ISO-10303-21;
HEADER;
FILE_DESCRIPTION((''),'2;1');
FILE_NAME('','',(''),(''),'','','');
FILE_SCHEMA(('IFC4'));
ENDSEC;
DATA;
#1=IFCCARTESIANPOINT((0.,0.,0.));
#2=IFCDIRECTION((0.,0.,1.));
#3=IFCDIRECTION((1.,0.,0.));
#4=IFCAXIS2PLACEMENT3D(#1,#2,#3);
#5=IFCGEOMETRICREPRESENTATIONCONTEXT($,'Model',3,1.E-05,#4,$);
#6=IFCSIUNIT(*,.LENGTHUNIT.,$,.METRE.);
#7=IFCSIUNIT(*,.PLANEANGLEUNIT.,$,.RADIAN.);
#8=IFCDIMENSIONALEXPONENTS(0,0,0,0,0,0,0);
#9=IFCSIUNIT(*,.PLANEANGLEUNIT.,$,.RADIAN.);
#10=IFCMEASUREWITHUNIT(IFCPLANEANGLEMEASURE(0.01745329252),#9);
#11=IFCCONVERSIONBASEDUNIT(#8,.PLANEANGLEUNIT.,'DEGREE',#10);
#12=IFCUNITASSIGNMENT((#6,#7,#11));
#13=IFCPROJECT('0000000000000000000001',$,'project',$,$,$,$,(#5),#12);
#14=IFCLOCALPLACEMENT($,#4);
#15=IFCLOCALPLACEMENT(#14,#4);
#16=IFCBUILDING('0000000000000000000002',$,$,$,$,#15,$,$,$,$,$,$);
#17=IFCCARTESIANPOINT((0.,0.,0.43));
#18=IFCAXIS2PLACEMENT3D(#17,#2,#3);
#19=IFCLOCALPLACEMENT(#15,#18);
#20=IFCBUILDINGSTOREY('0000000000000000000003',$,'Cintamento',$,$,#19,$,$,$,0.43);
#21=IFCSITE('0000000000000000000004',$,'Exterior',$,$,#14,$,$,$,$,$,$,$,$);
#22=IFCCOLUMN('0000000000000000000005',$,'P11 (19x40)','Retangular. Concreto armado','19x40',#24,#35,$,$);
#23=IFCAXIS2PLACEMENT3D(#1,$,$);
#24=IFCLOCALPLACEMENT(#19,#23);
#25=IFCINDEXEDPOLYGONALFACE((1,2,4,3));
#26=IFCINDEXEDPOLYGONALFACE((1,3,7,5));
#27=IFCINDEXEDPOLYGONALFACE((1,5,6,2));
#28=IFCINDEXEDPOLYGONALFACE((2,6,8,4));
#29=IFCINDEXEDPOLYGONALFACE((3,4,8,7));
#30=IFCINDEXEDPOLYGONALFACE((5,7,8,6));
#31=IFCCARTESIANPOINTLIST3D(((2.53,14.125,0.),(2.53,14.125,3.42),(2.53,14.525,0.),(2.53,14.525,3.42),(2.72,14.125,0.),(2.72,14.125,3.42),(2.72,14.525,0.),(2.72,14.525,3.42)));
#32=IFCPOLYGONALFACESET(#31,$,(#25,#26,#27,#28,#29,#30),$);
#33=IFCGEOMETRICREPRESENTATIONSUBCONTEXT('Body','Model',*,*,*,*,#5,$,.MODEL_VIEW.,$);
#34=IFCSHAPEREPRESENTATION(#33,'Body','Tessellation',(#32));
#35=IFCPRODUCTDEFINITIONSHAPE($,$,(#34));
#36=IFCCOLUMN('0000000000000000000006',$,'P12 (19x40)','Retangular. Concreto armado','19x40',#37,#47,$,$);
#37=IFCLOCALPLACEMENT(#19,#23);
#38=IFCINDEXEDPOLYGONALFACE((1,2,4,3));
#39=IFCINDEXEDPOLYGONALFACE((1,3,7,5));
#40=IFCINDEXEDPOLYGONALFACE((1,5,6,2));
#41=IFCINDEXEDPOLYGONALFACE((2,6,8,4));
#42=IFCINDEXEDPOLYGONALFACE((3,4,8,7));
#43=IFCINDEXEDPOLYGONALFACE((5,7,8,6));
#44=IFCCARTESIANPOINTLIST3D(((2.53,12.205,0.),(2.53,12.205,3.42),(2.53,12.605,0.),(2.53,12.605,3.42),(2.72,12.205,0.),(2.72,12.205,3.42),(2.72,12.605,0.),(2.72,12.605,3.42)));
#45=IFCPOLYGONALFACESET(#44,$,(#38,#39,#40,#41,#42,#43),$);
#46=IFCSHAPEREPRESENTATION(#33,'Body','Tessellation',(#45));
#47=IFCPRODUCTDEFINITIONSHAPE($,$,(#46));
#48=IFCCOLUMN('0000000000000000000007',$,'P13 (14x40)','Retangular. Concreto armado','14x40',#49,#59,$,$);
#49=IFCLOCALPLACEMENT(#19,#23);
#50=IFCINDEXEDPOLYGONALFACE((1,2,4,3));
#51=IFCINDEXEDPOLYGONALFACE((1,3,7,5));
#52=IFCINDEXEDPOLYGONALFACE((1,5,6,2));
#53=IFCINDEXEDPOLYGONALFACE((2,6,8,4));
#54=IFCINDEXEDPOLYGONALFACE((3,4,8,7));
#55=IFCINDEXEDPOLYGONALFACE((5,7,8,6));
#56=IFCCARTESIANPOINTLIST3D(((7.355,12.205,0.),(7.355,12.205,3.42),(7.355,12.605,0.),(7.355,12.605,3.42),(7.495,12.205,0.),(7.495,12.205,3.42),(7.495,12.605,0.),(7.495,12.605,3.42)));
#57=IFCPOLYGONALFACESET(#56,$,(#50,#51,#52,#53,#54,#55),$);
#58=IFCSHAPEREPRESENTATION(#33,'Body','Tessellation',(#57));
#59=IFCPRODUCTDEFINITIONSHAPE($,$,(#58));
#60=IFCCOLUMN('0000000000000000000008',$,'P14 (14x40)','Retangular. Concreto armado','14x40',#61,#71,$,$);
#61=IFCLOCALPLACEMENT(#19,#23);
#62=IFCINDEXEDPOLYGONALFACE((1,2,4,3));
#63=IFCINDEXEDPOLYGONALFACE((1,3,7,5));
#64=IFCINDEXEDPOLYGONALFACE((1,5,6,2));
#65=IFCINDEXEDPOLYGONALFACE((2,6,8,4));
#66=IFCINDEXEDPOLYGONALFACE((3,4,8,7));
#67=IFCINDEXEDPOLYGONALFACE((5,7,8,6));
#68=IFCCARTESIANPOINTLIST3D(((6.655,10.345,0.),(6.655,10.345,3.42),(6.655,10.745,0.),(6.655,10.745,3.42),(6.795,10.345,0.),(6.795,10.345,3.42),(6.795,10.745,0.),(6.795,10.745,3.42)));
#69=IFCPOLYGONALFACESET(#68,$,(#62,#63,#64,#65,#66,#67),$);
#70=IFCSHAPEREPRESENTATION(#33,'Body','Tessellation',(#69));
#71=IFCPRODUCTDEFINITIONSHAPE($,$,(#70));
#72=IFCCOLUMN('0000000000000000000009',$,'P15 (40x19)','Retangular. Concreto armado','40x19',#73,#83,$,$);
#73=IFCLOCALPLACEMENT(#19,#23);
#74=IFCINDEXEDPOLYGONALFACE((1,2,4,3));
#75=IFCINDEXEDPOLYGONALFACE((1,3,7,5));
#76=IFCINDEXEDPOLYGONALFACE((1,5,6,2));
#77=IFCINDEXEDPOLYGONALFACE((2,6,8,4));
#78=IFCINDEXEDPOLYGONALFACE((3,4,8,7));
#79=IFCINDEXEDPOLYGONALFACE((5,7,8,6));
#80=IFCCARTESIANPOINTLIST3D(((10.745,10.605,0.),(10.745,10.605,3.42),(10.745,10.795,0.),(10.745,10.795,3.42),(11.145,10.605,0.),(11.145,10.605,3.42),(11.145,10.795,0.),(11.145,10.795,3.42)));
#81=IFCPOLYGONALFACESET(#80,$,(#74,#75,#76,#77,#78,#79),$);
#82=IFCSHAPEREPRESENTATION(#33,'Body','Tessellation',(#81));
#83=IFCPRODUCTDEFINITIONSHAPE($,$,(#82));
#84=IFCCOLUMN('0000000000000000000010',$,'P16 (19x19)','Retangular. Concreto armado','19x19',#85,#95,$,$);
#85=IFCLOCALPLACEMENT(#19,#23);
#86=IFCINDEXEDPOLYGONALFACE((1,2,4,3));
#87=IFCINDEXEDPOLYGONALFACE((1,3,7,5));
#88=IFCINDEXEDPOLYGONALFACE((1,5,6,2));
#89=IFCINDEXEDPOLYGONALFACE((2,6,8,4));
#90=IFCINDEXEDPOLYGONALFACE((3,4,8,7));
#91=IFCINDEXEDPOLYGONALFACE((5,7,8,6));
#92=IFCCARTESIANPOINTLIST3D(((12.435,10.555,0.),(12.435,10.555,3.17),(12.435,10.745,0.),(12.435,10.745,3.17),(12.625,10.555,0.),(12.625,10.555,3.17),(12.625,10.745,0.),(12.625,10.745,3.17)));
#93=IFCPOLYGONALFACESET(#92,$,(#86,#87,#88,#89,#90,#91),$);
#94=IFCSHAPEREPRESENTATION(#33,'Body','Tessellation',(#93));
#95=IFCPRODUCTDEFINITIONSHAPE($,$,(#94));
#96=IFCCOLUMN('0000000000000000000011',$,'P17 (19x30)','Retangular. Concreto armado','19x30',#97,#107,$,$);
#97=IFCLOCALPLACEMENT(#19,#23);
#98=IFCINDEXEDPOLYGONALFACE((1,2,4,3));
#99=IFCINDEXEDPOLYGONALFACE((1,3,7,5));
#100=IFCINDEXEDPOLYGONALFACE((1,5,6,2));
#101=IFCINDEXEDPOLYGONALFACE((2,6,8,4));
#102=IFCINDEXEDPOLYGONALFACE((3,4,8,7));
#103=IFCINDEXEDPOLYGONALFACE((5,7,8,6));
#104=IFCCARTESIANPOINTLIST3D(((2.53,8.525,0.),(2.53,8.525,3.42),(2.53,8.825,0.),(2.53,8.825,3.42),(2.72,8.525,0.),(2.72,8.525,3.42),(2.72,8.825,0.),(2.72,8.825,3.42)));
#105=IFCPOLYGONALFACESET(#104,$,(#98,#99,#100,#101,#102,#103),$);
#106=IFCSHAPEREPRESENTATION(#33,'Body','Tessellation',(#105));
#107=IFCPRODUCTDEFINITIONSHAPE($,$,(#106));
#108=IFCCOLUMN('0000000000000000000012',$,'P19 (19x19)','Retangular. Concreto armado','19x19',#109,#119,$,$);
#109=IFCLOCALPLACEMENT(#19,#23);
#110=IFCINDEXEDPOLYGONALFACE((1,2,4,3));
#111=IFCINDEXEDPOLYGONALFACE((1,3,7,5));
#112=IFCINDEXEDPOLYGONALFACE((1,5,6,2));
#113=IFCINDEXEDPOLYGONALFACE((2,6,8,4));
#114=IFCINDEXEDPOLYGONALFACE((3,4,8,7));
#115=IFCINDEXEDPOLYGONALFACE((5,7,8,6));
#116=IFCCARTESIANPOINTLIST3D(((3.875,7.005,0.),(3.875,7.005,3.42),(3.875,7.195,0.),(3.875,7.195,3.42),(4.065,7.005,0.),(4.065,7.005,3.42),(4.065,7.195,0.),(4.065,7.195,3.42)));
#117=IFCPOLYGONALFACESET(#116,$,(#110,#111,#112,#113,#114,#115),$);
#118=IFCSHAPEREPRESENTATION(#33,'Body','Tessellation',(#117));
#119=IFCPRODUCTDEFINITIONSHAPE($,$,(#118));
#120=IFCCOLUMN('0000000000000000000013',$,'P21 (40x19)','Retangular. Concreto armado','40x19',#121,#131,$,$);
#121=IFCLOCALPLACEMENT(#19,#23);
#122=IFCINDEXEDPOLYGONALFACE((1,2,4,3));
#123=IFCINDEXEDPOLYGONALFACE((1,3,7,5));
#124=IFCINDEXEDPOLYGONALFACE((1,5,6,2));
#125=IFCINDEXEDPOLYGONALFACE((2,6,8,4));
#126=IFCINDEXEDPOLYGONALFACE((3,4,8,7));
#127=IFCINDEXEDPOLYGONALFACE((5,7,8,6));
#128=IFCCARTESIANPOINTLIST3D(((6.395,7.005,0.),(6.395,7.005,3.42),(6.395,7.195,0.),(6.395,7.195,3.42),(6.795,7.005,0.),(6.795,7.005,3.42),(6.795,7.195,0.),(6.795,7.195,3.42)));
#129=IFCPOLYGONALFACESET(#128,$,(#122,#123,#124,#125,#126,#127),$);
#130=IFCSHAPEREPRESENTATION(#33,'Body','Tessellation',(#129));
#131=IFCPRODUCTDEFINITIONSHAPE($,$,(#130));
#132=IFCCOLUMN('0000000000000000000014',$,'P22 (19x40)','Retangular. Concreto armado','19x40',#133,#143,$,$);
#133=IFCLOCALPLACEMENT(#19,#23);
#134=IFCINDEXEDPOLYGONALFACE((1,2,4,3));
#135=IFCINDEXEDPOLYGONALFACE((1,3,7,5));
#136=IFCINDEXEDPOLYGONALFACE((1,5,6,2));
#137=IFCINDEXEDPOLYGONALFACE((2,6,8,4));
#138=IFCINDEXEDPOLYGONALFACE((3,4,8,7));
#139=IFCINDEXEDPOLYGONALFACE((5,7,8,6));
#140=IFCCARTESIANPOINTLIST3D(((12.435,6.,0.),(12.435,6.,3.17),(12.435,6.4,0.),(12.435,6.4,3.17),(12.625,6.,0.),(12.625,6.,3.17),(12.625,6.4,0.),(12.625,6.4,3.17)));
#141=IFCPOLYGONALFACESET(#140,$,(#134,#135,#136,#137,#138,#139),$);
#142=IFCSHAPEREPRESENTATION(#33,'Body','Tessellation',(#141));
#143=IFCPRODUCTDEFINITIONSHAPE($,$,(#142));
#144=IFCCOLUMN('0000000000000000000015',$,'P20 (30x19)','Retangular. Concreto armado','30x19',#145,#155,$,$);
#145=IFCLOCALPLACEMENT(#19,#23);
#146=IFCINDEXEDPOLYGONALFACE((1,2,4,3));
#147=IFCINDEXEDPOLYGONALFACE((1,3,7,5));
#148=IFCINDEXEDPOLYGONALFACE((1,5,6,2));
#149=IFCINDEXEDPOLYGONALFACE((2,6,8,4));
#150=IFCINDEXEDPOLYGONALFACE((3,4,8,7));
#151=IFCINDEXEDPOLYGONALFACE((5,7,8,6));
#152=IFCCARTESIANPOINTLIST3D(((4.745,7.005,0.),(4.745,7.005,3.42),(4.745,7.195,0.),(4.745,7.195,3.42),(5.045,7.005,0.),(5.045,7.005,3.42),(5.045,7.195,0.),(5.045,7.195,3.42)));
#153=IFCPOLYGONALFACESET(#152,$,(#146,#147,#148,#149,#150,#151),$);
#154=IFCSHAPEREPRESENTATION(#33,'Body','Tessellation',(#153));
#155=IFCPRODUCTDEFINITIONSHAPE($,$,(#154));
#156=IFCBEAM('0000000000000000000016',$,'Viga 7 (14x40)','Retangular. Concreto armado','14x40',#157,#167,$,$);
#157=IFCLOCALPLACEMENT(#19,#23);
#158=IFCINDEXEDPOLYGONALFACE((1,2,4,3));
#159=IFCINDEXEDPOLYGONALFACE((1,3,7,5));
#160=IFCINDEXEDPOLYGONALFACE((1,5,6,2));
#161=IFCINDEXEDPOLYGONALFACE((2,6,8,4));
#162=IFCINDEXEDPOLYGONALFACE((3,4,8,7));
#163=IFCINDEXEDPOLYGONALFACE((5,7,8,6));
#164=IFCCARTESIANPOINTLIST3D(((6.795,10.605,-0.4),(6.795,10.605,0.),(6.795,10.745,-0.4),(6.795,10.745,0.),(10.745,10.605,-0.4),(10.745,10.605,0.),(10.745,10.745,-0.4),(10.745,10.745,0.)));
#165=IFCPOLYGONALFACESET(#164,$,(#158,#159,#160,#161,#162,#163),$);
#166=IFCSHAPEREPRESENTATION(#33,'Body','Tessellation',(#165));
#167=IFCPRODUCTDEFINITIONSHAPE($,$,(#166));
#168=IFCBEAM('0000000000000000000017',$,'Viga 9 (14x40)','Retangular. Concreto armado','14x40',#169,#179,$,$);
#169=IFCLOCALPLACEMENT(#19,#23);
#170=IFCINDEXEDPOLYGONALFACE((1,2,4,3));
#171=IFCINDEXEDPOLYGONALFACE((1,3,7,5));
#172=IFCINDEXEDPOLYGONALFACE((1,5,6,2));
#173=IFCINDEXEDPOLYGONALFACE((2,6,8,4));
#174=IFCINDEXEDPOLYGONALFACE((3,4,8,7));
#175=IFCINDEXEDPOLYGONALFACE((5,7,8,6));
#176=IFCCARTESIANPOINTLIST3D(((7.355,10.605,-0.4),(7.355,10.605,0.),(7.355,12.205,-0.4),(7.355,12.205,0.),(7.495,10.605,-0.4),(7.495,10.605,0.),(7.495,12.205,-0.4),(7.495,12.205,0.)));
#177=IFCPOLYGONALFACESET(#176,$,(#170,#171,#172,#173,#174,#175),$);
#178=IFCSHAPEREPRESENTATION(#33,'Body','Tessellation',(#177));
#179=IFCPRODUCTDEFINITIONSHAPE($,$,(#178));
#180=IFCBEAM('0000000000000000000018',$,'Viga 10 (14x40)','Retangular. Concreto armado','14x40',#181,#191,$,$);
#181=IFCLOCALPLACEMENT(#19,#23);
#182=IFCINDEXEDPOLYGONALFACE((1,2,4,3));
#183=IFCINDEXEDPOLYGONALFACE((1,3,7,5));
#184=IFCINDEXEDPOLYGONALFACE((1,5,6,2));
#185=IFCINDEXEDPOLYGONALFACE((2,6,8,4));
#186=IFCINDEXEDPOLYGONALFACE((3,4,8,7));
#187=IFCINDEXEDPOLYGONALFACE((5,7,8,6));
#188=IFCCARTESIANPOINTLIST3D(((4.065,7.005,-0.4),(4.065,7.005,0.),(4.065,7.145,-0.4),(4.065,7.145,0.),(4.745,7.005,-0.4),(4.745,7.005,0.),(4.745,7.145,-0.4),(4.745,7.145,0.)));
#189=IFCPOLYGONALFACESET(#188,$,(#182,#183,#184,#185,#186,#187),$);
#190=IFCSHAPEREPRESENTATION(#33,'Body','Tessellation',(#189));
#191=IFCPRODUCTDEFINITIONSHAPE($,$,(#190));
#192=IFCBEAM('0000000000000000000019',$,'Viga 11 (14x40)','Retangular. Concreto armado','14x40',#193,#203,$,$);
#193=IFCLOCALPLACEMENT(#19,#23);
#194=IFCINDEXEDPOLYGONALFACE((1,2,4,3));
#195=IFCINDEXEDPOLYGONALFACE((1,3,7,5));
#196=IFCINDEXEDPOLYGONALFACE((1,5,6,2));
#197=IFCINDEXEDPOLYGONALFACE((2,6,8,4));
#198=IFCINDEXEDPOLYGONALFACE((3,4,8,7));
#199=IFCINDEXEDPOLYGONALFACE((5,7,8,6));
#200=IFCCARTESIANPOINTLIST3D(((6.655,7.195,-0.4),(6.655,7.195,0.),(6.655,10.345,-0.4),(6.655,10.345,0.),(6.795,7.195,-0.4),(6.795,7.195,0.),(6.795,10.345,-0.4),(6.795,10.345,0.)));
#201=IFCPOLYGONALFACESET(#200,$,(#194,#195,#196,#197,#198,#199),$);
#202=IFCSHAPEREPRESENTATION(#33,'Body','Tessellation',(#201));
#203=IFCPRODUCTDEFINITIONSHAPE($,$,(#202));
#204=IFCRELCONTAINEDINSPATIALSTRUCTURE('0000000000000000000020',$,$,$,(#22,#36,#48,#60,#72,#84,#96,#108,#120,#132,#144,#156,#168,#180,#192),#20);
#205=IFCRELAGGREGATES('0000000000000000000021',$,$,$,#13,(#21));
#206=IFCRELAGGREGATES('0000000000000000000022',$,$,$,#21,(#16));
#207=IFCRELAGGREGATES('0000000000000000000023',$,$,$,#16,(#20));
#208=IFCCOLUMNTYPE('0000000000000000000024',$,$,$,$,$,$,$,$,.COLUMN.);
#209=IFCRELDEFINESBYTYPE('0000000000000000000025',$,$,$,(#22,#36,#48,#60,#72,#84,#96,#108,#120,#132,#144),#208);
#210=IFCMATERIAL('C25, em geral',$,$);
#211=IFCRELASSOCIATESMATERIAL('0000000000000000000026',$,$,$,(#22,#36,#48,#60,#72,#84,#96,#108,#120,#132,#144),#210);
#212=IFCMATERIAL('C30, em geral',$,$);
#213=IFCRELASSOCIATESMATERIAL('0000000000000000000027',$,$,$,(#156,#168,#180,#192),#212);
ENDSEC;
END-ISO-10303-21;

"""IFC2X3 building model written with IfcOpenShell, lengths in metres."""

from ifc_helpers import new_model, entity, si_unit, converted_unit, frame, frame_2d, origin_with_axes, place, context, subcontext, project, spatial, rectangle, extrude, material, type_object, element, save


model = new_model("IFC2X3")

# Units and contexts
model_context = context("Model", 3, precision=1e-05, world=origin_with_axes())
body_context = subcontext(model_context, "Body", "Model", "MODEL_VIEW")
ifc_project = project(units=[si_unit("LENGTHUNIT", "METRE"), si_unit("PLANEANGLEUNIT", "RADIAN"), converted_unit("PLANEANGLEUNIT", "DEGREE", entity("IfcPlaneAngleMeasure", 0.01745329252), si_unit("PLANEANGLEUNIT", "RADIAN"), dimensions=[0, 0, 0, 0, 0, 0, 0])], contexts=[model_context])

# Site, building, storey
site_placement = place(None, origin_with_axes())
site = spatial("IfcSite", under=ifc_project, at=site_placement, Name="Exterior")
building_placement = place(site_placement, origin_with_axes())
building = spatial("IfcBuilding", under=site, at=building_placement)
storey_placement = place(building_placement, frame((0.0, 0.0, 0.43), z_axis=(0.0, 0.0, 1.0), x_axis=(1.0, 0.0, 0.0)))
storey = spatial("IfcBuildingStorey", under=building, at=storey_placement, Name="Cintamento", Elevation=0.43)

# Columns
ifc_material_1 = material(Name="C25, em geral")
column_type = type_object("IfcColumnType", PredefinedType="COLUMN")
column_1_placement = place(storey_placement, frame((2.53, 14.525, 0.0), z_axis=(0.0, 0.0, 1.0), x_axis=(1.0, 0.0, 0.0)))
element("IfcColumn", 1, at=column_1_placement, inside=storey, type_object=column_type, material=ifc_material_1, Name="P11 (19x40)", Description="Retangular. Concreto armado", ObjectType="19x40", context=body_context, shape_type="SweptSolid", body=[
    extrude(rectangle(XDim=0.19, YDim=0.4, at=frame_2d((0.095, -0.2), x_axis=(1.0, 0.0))), origin_with_axes(), (0.0, 0.0, 1.0), 3.42),
])
column_2_placement = place(storey_placement, frame((2.53, 12.205, 0.0), z_axis=(0.0, 0.0, 1.0), x_axis=(1.0, 0.0, 0.0)))
element("IfcColumn", 2, at=column_2_placement, inside=storey, type_object=column_type, material=ifc_material_1, Name="P12 (19x40)", Description="Retangular. Concreto armado", ObjectType="19x40", context=body_context, shape_type="SweptSolid", body=[
    extrude(rectangle(XDim=0.19, YDim=0.4, at=frame_2d((0.095, 0.2), x_axis=(1.0, 0.0))), origin_with_axes(), (0.0, 0.0, 1.0), 3.42),
])
column_3_placement = place(storey_placement, frame((7.495, 12.205, 0.0), z_axis=(0.0, 0.0, 1.0), x_axis=(1.0, 0.0, 0.0)))
element("IfcColumn", 3, at=column_3_placement, inside=storey, type_object=column_type, material=ifc_material_1, Name="P13 (14x40)", Description="Retangular. Concreto armado", ObjectType="14x40", context=body_context, shape_type="SweptSolid", body=[
    extrude(rectangle(XDim=0.14, YDim=0.4, at=frame_2d((-0.07, 0.2), x_axis=(1.0, 0.0))), origin_with_axes(), (0.0, 0.0, 1.0), 3.42),
])
column_4_placement = place(storey_placement, frame((6.655, 10.745, 0.0), z_axis=(0.0, 0.0, 1.0), x_axis=(1.0, 0.0, 0.0)))
element("IfcColumn", 4, at=column_4_placement, inside=storey, type_object=column_type, material=ifc_material_1, Name="P14 (14x40)", Description="Retangular. Concreto armado", ObjectType="14x40", context=body_context, shape_type="SweptSolid", body=[
    extrude(rectangle(XDim=0.14, YDim=0.4, at=frame_2d((0.07, -0.2), x_axis=(1.0, 0.0))), origin_with_axes(), (0.0, 0.0, 1.0), 3.42),
])
column_5_placement = place(storey_placement, frame((11.145, 10.605, 0.0), z_axis=(0.0, 0.0, 1.0), x_axis=(1.0, 0.0, 0.0)))
element("IfcColumn", 5, at=column_5_placement, inside=storey, type_object=column_type, material=ifc_material_1, Name="P15 (40x19)", Description="Retangular. Concreto armado", ObjectType="40x19", context=body_context, shape_type="SweptSolid", body=[
    extrude(rectangle(XDim=0.4, YDim=0.19, at=frame_2d((-0.2, 0.095), x_axis=(1.0, 0.0))), origin_with_axes(), (0.0, 0.0, 1.0), 3.42),
])
column_6_placement = place(storey_placement, frame((12.625, 10.745, 0.0), z_axis=(0.0, 0.0, 1.0), x_axis=(1.0, 0.0, 0.0)))
element("IfcColumn", 6, at=column_6_placement, inside=storey, type_object=column_type, material=ifc_material_1, Name="P16 (19x19)", Description="Retangular. Concreto armado", ObjectType="19x19", context=body_context, shape_type="SweptSolid", body=[
    extrude(rectangle(XDim=0.19, YDim=0.19, at=frame_2d((-0.095, -0.095), x_axis=(1.0, 0.0))), origin_with_axes(), (0.0, 0.0, 1.0), 3.17),
])
column_7_placement = place(storey_placement, frame((2.53, 8.525, 0.0), z_axis=(0.0, 0.0, 1.0), x_axis=(1.0, 0.0, 0.0)))
element("IfcColumn", 7, at=column_7_placement, inside=storey, type_object=column_type, material=ifc_material_1, Name="P17 (19x30)", Description="Retangular. Concreto armado", ObjectType="19x30", context=body_context, shape_type="SweptSolid", body=[
    extrude(rectangle(XDim=0.19, YDim=0.3, at=frame_2d((0.095, 0.15), x_axis=(1.0, 0.0))), origin_with_axes(), (0.0, 0.0, 1.0), 3.42),
])
column_8_placement = place(storey_placement, frame((3.875, 7.005, 0.0), z_axis=(0.0, 0.0, 1.0), x_axis=(1.0, 0.0, 0.0)))
element("IfcColumn", 8, at=column_8_placement, inside=storey, type_object=column_type, material=ifc_material_1, Name="P19 (19x19)", Description="Retangular. Concreto armado", ObjectType="19x19", context=body_context, shape_type="SweptSolid", body=[
    extrude(rectangle(XDim=0.19, YDim=0.19, at=frame_2d((0.095, 0.095), x_axis=(1.0, 0.0))), origin_with_axes(), (0.0, 0.0, 1.0), 3.42),
])
column_9_placement = place(storey_placement, frame((6.795, 7.005, 0.0), z_axis=(0.0, 0.0, 1.0), x_axis=(1.0, 0.0, 0.0)))
element("IfcColumn", 9, at=column_9_placement, inside=storey, type_object=column_type, material=ifc_material_1, Name="P21 (40x19)", Description="Retangular. Concreto armado", ObjectType="40x19", context=body_context, shape_type="SweptSolid", body=[
    extrude(rectangle(XDim=0.4, YDim=0.19, at=frame_2d((-0.2, 0.095), x_axis=(1.0, 0.0))), origin_with_axes(), (0.0, 0.0, 1.0), 3.42),
])
column_10_placement = place(storey_placement, frame((12.625, 6.0, 0.0), z_axis=(0.0, 0.0, 1.0), x_axis=(1.0, 0.0, 0.0)))
element("IfcColumn", 10, at=column_10_placement, inside=storey, type_object=column_type, material=ifc_material_1, Name="P22 (19x40)", Description="Retangular. Concreto armado", ObjectType="19x40", context=body_context, shape_type="SweptSolid", body=[
    extrude(rectangle(XDim=0.19, YDim=0.4, at=frame_2d((-0.095, 0.2), x_axis=(1.0, 0.0))), origin_with_axes(), (0.0, 0.0, 1.0), 3.17),
])
column_11_placement = place(storey_placement, frame((5.045, 7.005, 0.0), z_axis=(0.0, 0.0, 1.0), x_axis=(1.0, 0.0, 0.0)))
element("IfcColumn", 11, at=column_11_placement, inside=storey, type_object=column_type, material=ifc_material_1, Name="P20 (30x19)", Description="Retangular. Concreto armado", ObjectType="30x19", context=body_context, shape_type="SweptSolid", body=[
    extrude(rectangle(XDim=0.3, YDim=0.19, at=frame_2d((-0.15, 0.095), x_axis=(1.0, 0.0))), origin_with_axes(), (0.0, 0.0, 1.0), 3.42),
])

# Beams
ifc_material_2 = material(Name="C30, em geral")
beam_1_placement = place(storey_placement, frame((6.795, 10.675, 0.0), z_axis=(1.0, 0.0, 0.0), x_axis=(0.0, 1.0, 0.0)))
element("IfcBeam", 12, at=beam_1_placement, inside=storey, material=ifc_material_2, Name="Viga 7 (14x40)", Description="Retangular. Concreto armado", ObjectType="14x40", context=body_context, shape_type="SweptSolid", body=[
    extrude(rectangle(XDim=0.14, YDim=0.4, at=frame_2d((0.0, -0.2), x_axis=(1.0, 0.0))), origin_with_axes(), (0.0, 0.0, 1.0), 3.95),
])
beam_2_placement = place(storey_placement, frame((7.425, 12.205, 0.0), z_axis=(0.0, -1.0, 0.0), x_axis=(1.0, 0.0, 0.0)))
element("IfcBeam", 13, at=beam_2_placement, inside=storey, material=ifc_material_2, Name="Viga 9 (14x40)", Description="Retangular. Concreto armado", ObjectType="14x40", context=body_context, shape_type="SweptSolid", body=[
    extrude(rectangle(XDim=0.14, YDim=0.4, at=frame_2d((0.0, -0.2), x_axis=(1.0, 0.0))), origin_with_axes(), (0.0, 0.0, 1.0), 1.6),
])
beam_3_placement = place(storey_placement, frame((4.065, 7.075, 0.0), z_axis=(1.0, 0.0, 0.0), x_axis=(0.0, 1.0, 0.0)))
element("IfcBeam", 14, at=beam_3_placement, inside=storey, material=ifc_material_2, Name="Viga 10 (14x40)", Description="Retangular. Concreto armado", ObjectType="14x40", context=body_context, shape_type="SweptSolid", body=[
    extrude(rectangle(XDim=0.14, YDim=0.4, at=frame_2d((0.0, -0.2), x_axis=(1.0, 0.0))), origin_with_axes(), (0.0, 0.0, 1.0), 0.68),
])
beam_4_placement = place(storey_placement, frame((6.725, 7.195, 0.0), z_axis=(0.0, 1.0, 0.0), x_axis=(-1.0, 0.0, 0.0)))
element("IfcBeam", 15, at=beam_4_placement, inside=storey, material=ifc_material_2, Name="Viga 11 (14x40)", Description="Retangular. Concreto armado", ObjectType="14x40", context=body_context, shape_type="SweptSolid", body=[
    extrude(rectangle(XDim=0.14, YDim=0.4, at=frame_2d((0.0, -0.2), x_axis=(1.0, 0.0))), origin_with_axes(), (0.0, 0.0, 1.0), 3.15),
])

save(model, "model.ifc")
